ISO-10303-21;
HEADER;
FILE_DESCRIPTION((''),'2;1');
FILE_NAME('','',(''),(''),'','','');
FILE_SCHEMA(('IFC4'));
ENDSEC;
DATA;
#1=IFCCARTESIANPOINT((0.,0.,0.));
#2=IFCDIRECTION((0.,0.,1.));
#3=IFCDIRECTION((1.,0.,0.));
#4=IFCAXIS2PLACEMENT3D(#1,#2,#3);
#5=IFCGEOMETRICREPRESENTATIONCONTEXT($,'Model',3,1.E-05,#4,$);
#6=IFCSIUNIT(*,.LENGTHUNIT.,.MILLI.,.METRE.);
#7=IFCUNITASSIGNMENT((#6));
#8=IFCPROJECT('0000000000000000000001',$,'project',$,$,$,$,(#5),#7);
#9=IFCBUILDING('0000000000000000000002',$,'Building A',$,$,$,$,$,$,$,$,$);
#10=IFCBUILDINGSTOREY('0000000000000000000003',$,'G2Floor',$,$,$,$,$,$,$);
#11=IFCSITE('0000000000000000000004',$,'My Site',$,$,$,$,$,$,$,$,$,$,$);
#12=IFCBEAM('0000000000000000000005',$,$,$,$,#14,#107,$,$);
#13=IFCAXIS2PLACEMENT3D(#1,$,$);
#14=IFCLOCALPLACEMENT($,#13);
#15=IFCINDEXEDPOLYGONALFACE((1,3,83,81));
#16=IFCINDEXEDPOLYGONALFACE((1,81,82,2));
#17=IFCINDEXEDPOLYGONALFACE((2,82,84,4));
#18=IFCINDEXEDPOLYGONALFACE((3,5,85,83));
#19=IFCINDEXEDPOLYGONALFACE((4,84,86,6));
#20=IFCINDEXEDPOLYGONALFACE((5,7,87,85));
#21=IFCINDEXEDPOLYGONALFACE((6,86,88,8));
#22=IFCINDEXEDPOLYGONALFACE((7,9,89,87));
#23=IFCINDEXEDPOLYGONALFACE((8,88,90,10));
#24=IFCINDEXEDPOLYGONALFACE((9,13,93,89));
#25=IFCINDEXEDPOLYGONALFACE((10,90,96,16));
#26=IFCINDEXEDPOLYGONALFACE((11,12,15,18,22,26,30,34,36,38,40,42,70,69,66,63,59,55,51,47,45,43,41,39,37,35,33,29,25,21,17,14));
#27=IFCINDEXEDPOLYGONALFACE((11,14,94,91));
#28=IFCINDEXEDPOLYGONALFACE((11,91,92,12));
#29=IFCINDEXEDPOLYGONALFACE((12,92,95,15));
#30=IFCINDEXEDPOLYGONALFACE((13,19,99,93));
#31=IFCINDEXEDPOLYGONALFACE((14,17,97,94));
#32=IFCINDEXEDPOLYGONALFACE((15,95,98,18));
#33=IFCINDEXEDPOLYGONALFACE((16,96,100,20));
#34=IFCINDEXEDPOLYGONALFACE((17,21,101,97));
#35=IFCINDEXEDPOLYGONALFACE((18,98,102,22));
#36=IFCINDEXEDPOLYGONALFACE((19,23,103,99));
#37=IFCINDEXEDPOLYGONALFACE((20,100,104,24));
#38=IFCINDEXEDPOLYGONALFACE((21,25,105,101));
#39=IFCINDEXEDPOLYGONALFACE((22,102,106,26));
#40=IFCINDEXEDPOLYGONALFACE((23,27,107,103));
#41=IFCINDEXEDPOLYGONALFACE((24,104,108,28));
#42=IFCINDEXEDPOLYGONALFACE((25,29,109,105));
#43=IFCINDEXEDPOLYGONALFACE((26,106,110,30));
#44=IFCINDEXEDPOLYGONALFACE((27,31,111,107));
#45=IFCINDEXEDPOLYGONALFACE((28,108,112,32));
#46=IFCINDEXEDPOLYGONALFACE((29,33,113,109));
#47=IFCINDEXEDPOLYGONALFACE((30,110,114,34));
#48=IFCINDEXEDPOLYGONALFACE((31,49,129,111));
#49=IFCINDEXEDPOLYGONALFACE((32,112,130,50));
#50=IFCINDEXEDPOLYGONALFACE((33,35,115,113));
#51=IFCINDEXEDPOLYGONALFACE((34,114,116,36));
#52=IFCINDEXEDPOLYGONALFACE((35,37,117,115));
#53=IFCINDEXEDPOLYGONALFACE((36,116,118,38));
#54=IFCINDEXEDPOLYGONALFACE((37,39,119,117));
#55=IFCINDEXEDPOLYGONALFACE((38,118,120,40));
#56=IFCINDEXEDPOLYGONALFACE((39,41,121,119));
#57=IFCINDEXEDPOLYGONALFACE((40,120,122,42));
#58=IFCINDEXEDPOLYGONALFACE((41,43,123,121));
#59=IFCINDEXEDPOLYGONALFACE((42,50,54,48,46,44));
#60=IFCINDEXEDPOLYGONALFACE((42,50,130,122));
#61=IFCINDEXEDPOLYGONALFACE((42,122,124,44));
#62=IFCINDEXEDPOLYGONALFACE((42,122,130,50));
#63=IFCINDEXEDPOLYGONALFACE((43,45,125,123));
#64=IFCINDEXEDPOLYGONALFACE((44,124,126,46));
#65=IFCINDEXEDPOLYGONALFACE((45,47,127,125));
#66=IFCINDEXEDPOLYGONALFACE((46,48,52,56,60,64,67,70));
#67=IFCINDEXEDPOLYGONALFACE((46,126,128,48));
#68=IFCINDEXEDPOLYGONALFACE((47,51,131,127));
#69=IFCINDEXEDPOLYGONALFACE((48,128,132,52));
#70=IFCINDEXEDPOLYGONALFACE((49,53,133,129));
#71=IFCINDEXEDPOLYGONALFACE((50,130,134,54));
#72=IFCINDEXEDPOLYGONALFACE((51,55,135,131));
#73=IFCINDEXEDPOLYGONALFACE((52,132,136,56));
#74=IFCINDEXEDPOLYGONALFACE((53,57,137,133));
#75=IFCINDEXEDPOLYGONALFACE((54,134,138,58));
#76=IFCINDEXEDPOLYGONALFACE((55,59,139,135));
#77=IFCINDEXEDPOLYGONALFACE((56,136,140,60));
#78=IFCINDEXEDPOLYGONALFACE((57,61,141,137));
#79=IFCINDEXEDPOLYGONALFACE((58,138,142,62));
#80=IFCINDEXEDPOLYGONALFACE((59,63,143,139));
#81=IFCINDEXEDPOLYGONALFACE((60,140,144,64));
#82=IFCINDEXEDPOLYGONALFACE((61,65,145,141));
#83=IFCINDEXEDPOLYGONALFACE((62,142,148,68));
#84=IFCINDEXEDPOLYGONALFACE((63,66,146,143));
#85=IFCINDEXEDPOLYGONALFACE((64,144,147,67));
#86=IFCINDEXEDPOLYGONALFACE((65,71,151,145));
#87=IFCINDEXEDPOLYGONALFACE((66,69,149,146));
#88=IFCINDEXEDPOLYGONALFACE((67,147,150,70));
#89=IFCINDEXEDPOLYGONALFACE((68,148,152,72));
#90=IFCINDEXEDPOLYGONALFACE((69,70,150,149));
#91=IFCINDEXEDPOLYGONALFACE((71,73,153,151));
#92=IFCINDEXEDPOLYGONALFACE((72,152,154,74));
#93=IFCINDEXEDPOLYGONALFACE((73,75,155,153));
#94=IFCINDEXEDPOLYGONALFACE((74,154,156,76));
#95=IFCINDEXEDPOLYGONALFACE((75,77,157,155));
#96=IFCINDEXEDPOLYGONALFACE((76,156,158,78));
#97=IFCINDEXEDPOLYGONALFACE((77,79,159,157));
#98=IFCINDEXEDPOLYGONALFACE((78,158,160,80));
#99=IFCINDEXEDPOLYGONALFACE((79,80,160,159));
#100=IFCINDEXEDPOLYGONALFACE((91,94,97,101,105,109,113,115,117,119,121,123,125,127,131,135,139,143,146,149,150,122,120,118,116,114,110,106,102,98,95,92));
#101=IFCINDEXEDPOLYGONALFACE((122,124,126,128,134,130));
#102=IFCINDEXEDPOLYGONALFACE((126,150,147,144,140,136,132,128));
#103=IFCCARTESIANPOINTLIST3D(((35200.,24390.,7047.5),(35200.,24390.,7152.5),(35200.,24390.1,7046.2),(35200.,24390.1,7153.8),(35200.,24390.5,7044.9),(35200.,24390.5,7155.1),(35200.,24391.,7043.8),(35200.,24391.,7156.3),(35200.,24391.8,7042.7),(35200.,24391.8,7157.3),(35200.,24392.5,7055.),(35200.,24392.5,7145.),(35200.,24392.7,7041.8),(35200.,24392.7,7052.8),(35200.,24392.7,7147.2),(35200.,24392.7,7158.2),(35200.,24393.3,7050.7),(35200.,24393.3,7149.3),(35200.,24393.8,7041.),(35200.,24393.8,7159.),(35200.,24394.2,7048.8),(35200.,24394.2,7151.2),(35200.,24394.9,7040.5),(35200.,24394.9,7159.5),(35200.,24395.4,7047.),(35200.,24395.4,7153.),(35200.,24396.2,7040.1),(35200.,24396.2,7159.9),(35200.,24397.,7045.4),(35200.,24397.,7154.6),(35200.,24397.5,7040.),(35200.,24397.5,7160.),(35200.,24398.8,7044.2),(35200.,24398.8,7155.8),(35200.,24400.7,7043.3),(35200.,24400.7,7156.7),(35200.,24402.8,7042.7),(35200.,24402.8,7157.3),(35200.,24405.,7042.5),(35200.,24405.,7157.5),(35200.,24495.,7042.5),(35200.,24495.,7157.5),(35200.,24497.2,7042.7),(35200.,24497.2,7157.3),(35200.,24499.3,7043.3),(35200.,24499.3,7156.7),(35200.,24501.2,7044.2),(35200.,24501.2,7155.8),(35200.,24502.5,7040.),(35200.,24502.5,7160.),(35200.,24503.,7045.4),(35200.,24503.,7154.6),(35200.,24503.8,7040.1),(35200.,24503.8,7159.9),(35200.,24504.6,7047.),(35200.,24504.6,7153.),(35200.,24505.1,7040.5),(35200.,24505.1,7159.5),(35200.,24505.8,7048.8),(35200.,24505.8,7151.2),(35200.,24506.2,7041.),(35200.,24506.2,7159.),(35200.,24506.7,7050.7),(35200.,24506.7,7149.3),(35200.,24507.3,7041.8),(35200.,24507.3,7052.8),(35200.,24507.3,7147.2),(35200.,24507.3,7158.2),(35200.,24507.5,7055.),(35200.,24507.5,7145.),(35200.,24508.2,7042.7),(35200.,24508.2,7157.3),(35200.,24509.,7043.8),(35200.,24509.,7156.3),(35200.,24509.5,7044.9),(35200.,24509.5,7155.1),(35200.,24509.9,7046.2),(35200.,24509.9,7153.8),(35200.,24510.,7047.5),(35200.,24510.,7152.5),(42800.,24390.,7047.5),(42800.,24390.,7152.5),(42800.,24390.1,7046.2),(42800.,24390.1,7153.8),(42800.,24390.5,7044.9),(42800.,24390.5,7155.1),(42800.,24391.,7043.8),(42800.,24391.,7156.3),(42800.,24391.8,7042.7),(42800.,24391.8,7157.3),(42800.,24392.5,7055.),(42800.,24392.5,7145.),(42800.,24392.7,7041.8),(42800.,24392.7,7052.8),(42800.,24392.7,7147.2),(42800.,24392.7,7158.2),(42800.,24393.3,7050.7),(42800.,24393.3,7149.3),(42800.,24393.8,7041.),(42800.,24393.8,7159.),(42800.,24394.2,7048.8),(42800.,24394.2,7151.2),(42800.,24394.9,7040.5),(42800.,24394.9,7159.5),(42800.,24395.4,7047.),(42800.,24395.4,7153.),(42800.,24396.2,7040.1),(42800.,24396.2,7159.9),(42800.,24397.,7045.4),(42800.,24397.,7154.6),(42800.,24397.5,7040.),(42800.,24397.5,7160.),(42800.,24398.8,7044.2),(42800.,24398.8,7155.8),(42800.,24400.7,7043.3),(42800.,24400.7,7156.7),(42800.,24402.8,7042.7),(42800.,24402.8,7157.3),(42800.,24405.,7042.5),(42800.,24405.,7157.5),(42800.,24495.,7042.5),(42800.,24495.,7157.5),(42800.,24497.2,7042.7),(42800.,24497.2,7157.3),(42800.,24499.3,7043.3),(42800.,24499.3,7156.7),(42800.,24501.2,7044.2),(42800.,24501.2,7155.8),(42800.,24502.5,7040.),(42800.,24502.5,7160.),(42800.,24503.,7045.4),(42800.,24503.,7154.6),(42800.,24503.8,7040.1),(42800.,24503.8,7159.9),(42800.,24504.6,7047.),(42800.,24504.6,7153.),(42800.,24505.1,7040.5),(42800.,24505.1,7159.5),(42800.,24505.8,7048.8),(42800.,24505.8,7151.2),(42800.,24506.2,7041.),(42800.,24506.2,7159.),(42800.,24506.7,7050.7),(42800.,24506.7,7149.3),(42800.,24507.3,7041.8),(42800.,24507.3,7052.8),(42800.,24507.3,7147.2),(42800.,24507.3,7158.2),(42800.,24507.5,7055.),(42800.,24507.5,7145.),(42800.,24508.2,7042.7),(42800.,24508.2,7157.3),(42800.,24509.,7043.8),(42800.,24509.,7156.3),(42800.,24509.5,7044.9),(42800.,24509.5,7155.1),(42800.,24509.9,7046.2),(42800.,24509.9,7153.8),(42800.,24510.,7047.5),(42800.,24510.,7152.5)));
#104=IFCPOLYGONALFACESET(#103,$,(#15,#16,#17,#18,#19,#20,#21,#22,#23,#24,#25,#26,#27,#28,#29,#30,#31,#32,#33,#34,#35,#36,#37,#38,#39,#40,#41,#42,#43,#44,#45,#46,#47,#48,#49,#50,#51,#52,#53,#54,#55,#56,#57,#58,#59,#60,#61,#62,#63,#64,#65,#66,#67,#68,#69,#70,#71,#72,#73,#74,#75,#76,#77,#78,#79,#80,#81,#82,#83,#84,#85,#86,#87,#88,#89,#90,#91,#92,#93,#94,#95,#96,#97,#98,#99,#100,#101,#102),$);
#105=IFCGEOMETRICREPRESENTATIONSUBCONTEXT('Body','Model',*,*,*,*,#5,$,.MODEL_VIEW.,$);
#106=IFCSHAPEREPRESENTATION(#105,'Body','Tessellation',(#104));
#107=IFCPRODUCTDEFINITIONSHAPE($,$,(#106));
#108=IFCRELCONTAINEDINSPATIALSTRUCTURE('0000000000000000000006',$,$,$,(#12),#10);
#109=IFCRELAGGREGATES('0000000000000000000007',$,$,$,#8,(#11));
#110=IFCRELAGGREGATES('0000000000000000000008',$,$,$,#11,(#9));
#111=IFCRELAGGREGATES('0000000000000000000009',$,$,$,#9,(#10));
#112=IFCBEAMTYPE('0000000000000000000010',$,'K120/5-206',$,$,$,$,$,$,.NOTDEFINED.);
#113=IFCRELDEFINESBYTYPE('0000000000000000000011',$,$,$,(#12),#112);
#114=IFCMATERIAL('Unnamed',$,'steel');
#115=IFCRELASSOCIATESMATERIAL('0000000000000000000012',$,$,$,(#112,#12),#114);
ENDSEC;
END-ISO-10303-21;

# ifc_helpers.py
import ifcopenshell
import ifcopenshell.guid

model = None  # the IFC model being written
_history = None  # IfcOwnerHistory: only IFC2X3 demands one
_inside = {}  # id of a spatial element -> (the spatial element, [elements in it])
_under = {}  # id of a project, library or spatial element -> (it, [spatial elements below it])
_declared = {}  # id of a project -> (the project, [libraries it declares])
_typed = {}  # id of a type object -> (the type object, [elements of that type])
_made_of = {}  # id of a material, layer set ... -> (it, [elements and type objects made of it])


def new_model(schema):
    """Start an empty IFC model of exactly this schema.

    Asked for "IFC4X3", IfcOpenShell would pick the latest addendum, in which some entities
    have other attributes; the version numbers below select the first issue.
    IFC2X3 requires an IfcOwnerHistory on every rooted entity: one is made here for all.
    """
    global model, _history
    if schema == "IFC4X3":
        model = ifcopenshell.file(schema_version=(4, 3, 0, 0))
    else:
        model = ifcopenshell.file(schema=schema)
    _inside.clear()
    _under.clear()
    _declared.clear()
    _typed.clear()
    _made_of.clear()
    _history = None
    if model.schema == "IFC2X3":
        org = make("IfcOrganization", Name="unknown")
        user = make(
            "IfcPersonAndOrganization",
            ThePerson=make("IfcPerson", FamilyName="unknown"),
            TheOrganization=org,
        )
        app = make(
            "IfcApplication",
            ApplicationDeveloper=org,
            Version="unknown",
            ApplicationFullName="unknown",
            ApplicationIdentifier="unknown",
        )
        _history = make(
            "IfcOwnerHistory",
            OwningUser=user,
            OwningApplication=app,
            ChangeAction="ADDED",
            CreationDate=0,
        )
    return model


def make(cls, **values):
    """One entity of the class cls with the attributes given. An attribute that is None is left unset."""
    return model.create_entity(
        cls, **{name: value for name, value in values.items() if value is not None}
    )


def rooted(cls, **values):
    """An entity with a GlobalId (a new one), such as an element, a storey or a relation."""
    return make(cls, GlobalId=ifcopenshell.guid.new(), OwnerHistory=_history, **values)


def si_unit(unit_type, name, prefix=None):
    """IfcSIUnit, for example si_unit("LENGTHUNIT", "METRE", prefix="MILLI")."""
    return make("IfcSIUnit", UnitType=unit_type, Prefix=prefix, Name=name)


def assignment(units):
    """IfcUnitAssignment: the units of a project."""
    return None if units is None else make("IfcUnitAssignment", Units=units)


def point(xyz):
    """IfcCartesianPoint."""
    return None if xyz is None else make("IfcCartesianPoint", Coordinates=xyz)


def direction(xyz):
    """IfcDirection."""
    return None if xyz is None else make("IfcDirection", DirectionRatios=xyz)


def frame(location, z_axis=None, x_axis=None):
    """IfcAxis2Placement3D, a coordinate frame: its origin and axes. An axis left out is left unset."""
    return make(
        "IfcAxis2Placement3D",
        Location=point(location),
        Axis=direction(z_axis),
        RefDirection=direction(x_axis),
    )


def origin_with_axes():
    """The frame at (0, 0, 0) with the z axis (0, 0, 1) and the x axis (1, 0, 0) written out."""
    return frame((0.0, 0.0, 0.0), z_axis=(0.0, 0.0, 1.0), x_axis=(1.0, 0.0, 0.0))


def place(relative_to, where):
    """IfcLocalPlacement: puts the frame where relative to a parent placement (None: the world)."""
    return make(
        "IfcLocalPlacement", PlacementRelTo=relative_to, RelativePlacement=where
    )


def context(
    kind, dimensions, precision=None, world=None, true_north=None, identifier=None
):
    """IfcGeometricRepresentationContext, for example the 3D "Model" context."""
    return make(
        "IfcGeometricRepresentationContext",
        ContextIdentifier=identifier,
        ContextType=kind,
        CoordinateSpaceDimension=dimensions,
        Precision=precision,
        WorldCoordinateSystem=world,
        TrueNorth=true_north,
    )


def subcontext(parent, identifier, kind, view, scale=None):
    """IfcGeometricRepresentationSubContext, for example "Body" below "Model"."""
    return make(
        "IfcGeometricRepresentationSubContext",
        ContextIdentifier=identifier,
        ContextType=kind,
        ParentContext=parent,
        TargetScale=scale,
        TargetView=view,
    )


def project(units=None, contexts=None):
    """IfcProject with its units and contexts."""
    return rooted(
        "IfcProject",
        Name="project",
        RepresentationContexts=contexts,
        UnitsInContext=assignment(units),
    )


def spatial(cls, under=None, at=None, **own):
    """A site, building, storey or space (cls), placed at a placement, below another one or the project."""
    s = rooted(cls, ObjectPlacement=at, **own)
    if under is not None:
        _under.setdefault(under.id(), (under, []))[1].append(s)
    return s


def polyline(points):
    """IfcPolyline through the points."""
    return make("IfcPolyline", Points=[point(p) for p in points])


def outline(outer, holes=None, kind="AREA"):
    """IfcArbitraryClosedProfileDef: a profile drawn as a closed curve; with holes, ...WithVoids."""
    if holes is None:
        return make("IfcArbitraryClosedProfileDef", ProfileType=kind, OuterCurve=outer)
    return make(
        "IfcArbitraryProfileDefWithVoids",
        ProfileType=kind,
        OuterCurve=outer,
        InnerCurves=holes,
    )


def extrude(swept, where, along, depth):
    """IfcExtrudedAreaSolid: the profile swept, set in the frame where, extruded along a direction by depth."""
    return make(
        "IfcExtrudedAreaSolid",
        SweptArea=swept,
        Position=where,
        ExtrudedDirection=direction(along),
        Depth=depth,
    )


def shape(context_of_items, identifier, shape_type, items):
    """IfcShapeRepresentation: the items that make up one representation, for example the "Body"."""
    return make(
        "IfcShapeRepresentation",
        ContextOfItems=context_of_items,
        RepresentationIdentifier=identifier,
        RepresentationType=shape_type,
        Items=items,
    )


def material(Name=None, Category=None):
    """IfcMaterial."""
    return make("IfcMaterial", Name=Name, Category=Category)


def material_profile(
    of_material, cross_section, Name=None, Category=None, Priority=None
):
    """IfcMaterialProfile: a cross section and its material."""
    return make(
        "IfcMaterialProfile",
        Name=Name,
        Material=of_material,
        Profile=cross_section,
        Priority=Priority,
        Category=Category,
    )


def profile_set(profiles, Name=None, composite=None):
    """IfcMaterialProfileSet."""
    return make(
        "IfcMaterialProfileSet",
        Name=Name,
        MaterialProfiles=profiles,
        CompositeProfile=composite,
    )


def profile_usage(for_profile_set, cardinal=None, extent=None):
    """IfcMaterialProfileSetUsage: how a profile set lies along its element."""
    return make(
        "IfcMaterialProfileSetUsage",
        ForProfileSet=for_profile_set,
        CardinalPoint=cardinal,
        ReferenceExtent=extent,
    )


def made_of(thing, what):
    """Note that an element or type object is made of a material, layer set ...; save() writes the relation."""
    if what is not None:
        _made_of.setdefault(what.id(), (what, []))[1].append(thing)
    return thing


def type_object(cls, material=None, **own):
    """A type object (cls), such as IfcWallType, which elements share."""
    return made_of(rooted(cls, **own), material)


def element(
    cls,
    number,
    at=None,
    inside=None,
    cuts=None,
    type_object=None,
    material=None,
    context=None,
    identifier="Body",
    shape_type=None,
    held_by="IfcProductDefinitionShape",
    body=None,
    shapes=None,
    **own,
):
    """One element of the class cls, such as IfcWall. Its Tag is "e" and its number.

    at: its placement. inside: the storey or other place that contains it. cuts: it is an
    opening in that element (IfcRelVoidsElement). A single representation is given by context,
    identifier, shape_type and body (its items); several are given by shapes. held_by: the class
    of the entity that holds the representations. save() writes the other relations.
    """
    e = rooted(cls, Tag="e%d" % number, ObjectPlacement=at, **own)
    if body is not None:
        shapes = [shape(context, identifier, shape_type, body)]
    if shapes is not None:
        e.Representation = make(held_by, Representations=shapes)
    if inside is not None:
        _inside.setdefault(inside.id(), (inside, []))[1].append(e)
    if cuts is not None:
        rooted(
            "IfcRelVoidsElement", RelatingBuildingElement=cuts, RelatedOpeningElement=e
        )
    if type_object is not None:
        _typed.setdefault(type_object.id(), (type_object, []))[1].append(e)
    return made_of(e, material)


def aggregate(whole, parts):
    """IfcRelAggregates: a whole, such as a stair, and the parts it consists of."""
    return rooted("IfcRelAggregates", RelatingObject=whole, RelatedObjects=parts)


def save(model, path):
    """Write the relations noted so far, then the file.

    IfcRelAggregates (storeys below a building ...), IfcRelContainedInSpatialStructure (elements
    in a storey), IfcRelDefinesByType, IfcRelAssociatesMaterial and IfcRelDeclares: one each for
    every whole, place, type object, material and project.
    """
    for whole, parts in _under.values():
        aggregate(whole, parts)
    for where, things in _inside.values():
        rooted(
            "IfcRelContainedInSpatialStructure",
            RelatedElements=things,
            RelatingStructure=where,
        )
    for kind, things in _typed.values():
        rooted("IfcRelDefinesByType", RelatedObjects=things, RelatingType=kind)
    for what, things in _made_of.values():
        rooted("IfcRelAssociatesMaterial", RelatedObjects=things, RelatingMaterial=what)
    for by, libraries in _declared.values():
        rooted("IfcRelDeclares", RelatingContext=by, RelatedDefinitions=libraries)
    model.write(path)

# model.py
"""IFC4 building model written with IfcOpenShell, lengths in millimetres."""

from ifc_helpers import new_model, si_unit, frame, origin_with_axes, place, context, subcontext, project, spatial, polyline, outline, extrude, material, material_profile, profile_set, profile_usage, type_object, element, save


model = new_model("IFC4")

# Units and contexts
model_context = context("Model", 3, precision=1e-05, world=origin_with_axes())
body_context = subcontext(model_context, "Body", "Model", "MODEL_VIEW")
ifc_project = project(units=[si_unit("LENGTHUNIT", "METRE", prefix="MILLI")], contexts=[model_context])

# Site, building, storey
site = spatial("IfcSite", under=ifc_project, Name="My Site")
building = spatial("IfcBuilding", under=site, Name="Building A")
storey = spatial("IfcBuildingStorey", under=building, Name="G2Floor")

# Beam
ifc_material_1 = material(Name="Unnamed", Category="steel")
ifc_material_profile_1 = material_profile(ifc_material_1, outline(polyline([(-52.5, -60.0), (52.5, -60.0), (52.5, -60.0), (53.8, -59.9), (53.8, -59.9), (55.1, -59.5), (55.1, -59.5), (56.2, -59.0), (56.2, -59.0), (57.3, -58.2), (57.3, -58.2), (58.2, -57.3), (58.2, -57.3), (59.0, -56.2), (59.0, -56.2), (59.5, -55.1), (59.5, -55.1), (59.9, -53.8), (59.9, -53.8), (60.0, -52.5), (60.0, -52.5), (60.0, 52.5), (60.0, 52.5), (59.9, 53.8), (59.9, 53.8), (59.5, 55.1), (59.5, 55.1), (59.0, 56.2), (59.0, 56.2), (58.2, 57.3), (58.2, 57.3), (57.3, 58.2), (57.3, 58.2), (56.2, 59.0), (56.2, 59.0), (55.1, 59.5), (55.1, 59.5), (53.8, 59.9), (53.8, 59.9), (52.5, 60.0), (52.5, 60.0), (-52.5, 60.0), (-52.5, 60.0), (-53.8, 59.9), (-53.8, 59.9), (-55.1, 59.5), (-55.1, 59.5), (-56.2, 59.0), (-56.2, 59.0), (-57.3, 58.2), (-57.3, 58.2), (-58.2, 57.3), (-58.2, 57.3), (-59.0, 56.2), (-59.0, 56.2), (-59.5, 55.1), (-59.5, 55.1), (-59.9, 53.8), (-59.9, 53.8), (-60.0, 52.5), (-60.0, 52.5), (-60.0, -52.5), (-60.0, -52.5), (-59.9, -53.8), (-59.9, -53.8), (-59.5, -55.1), (-59.5, -55.1), (-59.0, -56.2), (-59.0, -56.2), (-58.2, -57.3), (-58.2, -57.3), (-57.3, -58.2), (-57.3, -58.2), (-56.2, -59.0), (-56.2, -59.0), (-55.1, -59.5), (-55.1, -59.5), (-53.8, -59.9), (-53.8, -59.9), (-52.5, -60.0), (-52.5, -60.0), (-45.0, -57.5), (-45.0, -57.5), (45.0, -57.5), (45.0, -57.5), (47.2, -57.3), (47.2, -57.3), (49.3, -56.7), (49.3, -56.7), (51.2, -55.8), (51.2, -55.8), (53.0, -54.6), (53.0, -54.6), (54.6, -53.0), (54.6, -53.0), (55.8, -51.2), (55.8, -51.2), (56.7, -49.3), (56.7, -49.3), (57.3, -47.2), (57.3, -47.2), (57.5, -45.0), (57.5, -45.0), (57.5, 45.0), (57.5, 45.0), (57.3, 47.2), (57.3, 47.2), (56.7, 49.3), (56.7, 49.3), (55.8, 51.2), (55.8, 51.2), (54.6, 53.0), (54.6, 53.0), (53.0, 54.6), (53.0, 54.6), (51.2, 55.8), (51.2, 55.8), (49.3, 56.7), (49.3, 56.7), (47.2, 57.3), (47.2, 57.3), (45.0, 57.5), (45.0, 57.5), (-45.0, 57.5), (-45.0, 57.5), (-47.2, 57.3), (-47.2, 57.3), (-49.3, 56.7), (-49.3, 56.7), (-51.2, 55.8), (-51.2, 55.8), (-53.0, 54.6), (-53.0, 54.6), (-54.6, 53.0), (-54.6, 53.0), (-55.8, 51.2), (-55.8, 51.2), (-56.7, 49.3), (-56.7, 49.3), (-57.3, 47.2), (-57.3, 47.2), (-57.5, 45.0), (-57.5, 45.0), (-57.5, -45.0), (-57.5, -45.0), (-57.3, -47.2), (-57.3, -47.2), (-56.7, -49.3), (-56.7, -49.3), (-55.8, -51.2), (-55.8, -51.2), (-54.6, -53.0), (-54.6, -53.0), (-53.0, -54.6), (-53.0, -54.6), (-51.2, -55.8), (-51.2, -55.8), (-49.3, -56.7), (-49.3, -56.7), (-47.2, -57.3), (-47.2, -57.3), (-45.0, -57.5), (-45.0, -57.5), (-52.5, -60.0)])))
ifc_profile_set_1 = profile_set([ifc_material_profile_1], Name="K120/5-206")
ifc_profile_usage_1 = profile_usage(ifc_profile_set_1)
beam_type_1 = type_object("IfcBeamType", Name="K120/5-206", PredefinedType="NOTDEFINED", material=ifc_profile_set_1)
beam_1_placement = place(None, frame((35200.0, 24450.0, 7100.0), z_axis=(1.0, 0.0, 0.0), x_axis=(0.0, -1.0, 0.0)))
element("IfcBeam", 1, at=beam_1_placement, inside=storey, type_object=beam_type_1, material=ifc_profile_usage_1, context=body_context, shape_type="SweptSolid", body=[
    extrude(outline(polyline([(-52.5, -60.0), (52.5, -60.0), (52.5, -60.0), (53.8, -59.9), (53.8, -59.9), (55.1, -59.5), (55.1, -59.5), (56.2, -59.0), (56.2, -59.0), (57.3, -58.2), (57.3, -58.2), (58.2, -57.3), (58.2, -57.3), (59.0, -56.2), (59.0, -56.2), (59.5, -55.1), (59.5, -55.1), (59.9, -53.8), (59.9, -53.8), (60.0, -52.5), (60.0, -52.5), (60.0, 52.5), (60.0, 52.5), (59.9, 53.8), (59.9, 53.8), (59.5, 55.1), (59.5, 55.1), (59.0, 56.2), (59.0, 56.2), (58.2, 57.3), (58.2, 57.3), (57.3, 58.2), (57.3, 58.2), (56.2, 59.0), (56.2, 59.0), (55.1, 59.5), (55.1, 59.5), (53.8, 59.9), (53.8, 59.9), (52.5, 60.0), (52.5, 60.0), (-52.5, 60.0), (-52.5, 60.0), (-53.8, 59.9), (-53.8, 59.9), (-55.1, 59.5), (-55.1, 59.5), (-56.2, 59.0), (-56.2, 59.0), (-57.3, 58.2), (-57.3, 58.2), (-58.2, 57.3), (-58.2, 57.3), (-59.0, 56.2), (-59.0, 56.2), (-59.5, 55.1), (-59.5, 55.1), (-59.9, 53.8), (-59.9, 53.8), (-60.0, 52.5), (-60.0, 52.5), (-60.0, -52.5), (-60.0, -52.5), (-59.9, -53.8), (-59.9, -53.8), (-59.5, -55.1), (-59.5, -55.1), (-59.0, -56.2), (-59.0, -56.2), (-58.2, -57.3), (-58.2, -57.3), (-57.3, -58.2), (-57.3, -58.2), (-56.2, -59.0), (-56.2, -59.0), (-55.1, -59.5), (-55.1, -59.5), (-53.8, -59.9), (-53.8, -59.9), (-52.5, -60.0), (-52.5, -60.0), (-45.0, -57.5), (-45.0, -57.5), (45.0, -57.5), (45.0, -57.5), (47.2, -57.3), (47.2, -57.3), (49.3, -56.7), (49.3, -56.7), (51.2, -55.8), (51.2, -55.8), (53.0, -54.6), (53.0, -54.6), (54.6, -53.0), (54.6, -53.0), (55.8, -51.2), (55.8, -51.2), (56.7, -49.3), (56.7, -49.3), (57.3, -47.2), (57.3, -47.2), (57.5, -45.0), (57.5, -45.0), (57.5, 45.0), (57.5, 45.0), (57.3, 47.2), (57.3, 47.2), (56.7, 49.3), (56.7, 49.3), (55.8, 51.2), (55.8, 51.2), (54.6, 53.0), (54.6, 53.0), (53.0, 54.6), (53.0, 54.6), (51.2, 55.8), (51.2, 55.8), (49.3, 56.7), (49.3, 56.7), (47.2, 57.3), (47.2, 57.3), (45.0, 57.5), (45.0, 57.5), (-45.0, 57.5), (-45.0, 57.5), (-47.2, 57.3), (-47.2, 57.3), (-49.3, 56.7), (-49.3, 56.7), (-51.2, 55.8), (-51.2, 55.8), (-53.0, 54.6), (-53.0, 54.6), (-54.6, 53.0), (-54.6, 53.0), (-55.8, 51.2), (-55.8, 51.2), (-56.7, 49.3), (-56.7, 49.3), (-57.3, 47.2), (-57.3, 47.2), (-57.5, 45.0), (-57.5, 45.0), (-57.5, -45.0), (-57.5, -45.0), (-57.3, -47.2), (-57.3, -47.2), (-56.7, -49.3), (-56.7, -49.3), (-55.8, -51.2), (-55.8, -51.2), (-54.6, -53.0), (-54.6, -53.0), (-53.0, -54.6), (-53.0, -54.6), (-51.2, -55.8), (-51.2, -55.8), (-49.3, -56.7), (-49.3, -56.7), (-47.2, -57.3), (-47.2, -57.3), (-45.0, -57.5), (-45.0, -57.5), (-52.5, -60.0)])), origin_with_axes(), (0.0, 0.0, 1.0), 7600.0),
])

save(model, "model.ifc")
